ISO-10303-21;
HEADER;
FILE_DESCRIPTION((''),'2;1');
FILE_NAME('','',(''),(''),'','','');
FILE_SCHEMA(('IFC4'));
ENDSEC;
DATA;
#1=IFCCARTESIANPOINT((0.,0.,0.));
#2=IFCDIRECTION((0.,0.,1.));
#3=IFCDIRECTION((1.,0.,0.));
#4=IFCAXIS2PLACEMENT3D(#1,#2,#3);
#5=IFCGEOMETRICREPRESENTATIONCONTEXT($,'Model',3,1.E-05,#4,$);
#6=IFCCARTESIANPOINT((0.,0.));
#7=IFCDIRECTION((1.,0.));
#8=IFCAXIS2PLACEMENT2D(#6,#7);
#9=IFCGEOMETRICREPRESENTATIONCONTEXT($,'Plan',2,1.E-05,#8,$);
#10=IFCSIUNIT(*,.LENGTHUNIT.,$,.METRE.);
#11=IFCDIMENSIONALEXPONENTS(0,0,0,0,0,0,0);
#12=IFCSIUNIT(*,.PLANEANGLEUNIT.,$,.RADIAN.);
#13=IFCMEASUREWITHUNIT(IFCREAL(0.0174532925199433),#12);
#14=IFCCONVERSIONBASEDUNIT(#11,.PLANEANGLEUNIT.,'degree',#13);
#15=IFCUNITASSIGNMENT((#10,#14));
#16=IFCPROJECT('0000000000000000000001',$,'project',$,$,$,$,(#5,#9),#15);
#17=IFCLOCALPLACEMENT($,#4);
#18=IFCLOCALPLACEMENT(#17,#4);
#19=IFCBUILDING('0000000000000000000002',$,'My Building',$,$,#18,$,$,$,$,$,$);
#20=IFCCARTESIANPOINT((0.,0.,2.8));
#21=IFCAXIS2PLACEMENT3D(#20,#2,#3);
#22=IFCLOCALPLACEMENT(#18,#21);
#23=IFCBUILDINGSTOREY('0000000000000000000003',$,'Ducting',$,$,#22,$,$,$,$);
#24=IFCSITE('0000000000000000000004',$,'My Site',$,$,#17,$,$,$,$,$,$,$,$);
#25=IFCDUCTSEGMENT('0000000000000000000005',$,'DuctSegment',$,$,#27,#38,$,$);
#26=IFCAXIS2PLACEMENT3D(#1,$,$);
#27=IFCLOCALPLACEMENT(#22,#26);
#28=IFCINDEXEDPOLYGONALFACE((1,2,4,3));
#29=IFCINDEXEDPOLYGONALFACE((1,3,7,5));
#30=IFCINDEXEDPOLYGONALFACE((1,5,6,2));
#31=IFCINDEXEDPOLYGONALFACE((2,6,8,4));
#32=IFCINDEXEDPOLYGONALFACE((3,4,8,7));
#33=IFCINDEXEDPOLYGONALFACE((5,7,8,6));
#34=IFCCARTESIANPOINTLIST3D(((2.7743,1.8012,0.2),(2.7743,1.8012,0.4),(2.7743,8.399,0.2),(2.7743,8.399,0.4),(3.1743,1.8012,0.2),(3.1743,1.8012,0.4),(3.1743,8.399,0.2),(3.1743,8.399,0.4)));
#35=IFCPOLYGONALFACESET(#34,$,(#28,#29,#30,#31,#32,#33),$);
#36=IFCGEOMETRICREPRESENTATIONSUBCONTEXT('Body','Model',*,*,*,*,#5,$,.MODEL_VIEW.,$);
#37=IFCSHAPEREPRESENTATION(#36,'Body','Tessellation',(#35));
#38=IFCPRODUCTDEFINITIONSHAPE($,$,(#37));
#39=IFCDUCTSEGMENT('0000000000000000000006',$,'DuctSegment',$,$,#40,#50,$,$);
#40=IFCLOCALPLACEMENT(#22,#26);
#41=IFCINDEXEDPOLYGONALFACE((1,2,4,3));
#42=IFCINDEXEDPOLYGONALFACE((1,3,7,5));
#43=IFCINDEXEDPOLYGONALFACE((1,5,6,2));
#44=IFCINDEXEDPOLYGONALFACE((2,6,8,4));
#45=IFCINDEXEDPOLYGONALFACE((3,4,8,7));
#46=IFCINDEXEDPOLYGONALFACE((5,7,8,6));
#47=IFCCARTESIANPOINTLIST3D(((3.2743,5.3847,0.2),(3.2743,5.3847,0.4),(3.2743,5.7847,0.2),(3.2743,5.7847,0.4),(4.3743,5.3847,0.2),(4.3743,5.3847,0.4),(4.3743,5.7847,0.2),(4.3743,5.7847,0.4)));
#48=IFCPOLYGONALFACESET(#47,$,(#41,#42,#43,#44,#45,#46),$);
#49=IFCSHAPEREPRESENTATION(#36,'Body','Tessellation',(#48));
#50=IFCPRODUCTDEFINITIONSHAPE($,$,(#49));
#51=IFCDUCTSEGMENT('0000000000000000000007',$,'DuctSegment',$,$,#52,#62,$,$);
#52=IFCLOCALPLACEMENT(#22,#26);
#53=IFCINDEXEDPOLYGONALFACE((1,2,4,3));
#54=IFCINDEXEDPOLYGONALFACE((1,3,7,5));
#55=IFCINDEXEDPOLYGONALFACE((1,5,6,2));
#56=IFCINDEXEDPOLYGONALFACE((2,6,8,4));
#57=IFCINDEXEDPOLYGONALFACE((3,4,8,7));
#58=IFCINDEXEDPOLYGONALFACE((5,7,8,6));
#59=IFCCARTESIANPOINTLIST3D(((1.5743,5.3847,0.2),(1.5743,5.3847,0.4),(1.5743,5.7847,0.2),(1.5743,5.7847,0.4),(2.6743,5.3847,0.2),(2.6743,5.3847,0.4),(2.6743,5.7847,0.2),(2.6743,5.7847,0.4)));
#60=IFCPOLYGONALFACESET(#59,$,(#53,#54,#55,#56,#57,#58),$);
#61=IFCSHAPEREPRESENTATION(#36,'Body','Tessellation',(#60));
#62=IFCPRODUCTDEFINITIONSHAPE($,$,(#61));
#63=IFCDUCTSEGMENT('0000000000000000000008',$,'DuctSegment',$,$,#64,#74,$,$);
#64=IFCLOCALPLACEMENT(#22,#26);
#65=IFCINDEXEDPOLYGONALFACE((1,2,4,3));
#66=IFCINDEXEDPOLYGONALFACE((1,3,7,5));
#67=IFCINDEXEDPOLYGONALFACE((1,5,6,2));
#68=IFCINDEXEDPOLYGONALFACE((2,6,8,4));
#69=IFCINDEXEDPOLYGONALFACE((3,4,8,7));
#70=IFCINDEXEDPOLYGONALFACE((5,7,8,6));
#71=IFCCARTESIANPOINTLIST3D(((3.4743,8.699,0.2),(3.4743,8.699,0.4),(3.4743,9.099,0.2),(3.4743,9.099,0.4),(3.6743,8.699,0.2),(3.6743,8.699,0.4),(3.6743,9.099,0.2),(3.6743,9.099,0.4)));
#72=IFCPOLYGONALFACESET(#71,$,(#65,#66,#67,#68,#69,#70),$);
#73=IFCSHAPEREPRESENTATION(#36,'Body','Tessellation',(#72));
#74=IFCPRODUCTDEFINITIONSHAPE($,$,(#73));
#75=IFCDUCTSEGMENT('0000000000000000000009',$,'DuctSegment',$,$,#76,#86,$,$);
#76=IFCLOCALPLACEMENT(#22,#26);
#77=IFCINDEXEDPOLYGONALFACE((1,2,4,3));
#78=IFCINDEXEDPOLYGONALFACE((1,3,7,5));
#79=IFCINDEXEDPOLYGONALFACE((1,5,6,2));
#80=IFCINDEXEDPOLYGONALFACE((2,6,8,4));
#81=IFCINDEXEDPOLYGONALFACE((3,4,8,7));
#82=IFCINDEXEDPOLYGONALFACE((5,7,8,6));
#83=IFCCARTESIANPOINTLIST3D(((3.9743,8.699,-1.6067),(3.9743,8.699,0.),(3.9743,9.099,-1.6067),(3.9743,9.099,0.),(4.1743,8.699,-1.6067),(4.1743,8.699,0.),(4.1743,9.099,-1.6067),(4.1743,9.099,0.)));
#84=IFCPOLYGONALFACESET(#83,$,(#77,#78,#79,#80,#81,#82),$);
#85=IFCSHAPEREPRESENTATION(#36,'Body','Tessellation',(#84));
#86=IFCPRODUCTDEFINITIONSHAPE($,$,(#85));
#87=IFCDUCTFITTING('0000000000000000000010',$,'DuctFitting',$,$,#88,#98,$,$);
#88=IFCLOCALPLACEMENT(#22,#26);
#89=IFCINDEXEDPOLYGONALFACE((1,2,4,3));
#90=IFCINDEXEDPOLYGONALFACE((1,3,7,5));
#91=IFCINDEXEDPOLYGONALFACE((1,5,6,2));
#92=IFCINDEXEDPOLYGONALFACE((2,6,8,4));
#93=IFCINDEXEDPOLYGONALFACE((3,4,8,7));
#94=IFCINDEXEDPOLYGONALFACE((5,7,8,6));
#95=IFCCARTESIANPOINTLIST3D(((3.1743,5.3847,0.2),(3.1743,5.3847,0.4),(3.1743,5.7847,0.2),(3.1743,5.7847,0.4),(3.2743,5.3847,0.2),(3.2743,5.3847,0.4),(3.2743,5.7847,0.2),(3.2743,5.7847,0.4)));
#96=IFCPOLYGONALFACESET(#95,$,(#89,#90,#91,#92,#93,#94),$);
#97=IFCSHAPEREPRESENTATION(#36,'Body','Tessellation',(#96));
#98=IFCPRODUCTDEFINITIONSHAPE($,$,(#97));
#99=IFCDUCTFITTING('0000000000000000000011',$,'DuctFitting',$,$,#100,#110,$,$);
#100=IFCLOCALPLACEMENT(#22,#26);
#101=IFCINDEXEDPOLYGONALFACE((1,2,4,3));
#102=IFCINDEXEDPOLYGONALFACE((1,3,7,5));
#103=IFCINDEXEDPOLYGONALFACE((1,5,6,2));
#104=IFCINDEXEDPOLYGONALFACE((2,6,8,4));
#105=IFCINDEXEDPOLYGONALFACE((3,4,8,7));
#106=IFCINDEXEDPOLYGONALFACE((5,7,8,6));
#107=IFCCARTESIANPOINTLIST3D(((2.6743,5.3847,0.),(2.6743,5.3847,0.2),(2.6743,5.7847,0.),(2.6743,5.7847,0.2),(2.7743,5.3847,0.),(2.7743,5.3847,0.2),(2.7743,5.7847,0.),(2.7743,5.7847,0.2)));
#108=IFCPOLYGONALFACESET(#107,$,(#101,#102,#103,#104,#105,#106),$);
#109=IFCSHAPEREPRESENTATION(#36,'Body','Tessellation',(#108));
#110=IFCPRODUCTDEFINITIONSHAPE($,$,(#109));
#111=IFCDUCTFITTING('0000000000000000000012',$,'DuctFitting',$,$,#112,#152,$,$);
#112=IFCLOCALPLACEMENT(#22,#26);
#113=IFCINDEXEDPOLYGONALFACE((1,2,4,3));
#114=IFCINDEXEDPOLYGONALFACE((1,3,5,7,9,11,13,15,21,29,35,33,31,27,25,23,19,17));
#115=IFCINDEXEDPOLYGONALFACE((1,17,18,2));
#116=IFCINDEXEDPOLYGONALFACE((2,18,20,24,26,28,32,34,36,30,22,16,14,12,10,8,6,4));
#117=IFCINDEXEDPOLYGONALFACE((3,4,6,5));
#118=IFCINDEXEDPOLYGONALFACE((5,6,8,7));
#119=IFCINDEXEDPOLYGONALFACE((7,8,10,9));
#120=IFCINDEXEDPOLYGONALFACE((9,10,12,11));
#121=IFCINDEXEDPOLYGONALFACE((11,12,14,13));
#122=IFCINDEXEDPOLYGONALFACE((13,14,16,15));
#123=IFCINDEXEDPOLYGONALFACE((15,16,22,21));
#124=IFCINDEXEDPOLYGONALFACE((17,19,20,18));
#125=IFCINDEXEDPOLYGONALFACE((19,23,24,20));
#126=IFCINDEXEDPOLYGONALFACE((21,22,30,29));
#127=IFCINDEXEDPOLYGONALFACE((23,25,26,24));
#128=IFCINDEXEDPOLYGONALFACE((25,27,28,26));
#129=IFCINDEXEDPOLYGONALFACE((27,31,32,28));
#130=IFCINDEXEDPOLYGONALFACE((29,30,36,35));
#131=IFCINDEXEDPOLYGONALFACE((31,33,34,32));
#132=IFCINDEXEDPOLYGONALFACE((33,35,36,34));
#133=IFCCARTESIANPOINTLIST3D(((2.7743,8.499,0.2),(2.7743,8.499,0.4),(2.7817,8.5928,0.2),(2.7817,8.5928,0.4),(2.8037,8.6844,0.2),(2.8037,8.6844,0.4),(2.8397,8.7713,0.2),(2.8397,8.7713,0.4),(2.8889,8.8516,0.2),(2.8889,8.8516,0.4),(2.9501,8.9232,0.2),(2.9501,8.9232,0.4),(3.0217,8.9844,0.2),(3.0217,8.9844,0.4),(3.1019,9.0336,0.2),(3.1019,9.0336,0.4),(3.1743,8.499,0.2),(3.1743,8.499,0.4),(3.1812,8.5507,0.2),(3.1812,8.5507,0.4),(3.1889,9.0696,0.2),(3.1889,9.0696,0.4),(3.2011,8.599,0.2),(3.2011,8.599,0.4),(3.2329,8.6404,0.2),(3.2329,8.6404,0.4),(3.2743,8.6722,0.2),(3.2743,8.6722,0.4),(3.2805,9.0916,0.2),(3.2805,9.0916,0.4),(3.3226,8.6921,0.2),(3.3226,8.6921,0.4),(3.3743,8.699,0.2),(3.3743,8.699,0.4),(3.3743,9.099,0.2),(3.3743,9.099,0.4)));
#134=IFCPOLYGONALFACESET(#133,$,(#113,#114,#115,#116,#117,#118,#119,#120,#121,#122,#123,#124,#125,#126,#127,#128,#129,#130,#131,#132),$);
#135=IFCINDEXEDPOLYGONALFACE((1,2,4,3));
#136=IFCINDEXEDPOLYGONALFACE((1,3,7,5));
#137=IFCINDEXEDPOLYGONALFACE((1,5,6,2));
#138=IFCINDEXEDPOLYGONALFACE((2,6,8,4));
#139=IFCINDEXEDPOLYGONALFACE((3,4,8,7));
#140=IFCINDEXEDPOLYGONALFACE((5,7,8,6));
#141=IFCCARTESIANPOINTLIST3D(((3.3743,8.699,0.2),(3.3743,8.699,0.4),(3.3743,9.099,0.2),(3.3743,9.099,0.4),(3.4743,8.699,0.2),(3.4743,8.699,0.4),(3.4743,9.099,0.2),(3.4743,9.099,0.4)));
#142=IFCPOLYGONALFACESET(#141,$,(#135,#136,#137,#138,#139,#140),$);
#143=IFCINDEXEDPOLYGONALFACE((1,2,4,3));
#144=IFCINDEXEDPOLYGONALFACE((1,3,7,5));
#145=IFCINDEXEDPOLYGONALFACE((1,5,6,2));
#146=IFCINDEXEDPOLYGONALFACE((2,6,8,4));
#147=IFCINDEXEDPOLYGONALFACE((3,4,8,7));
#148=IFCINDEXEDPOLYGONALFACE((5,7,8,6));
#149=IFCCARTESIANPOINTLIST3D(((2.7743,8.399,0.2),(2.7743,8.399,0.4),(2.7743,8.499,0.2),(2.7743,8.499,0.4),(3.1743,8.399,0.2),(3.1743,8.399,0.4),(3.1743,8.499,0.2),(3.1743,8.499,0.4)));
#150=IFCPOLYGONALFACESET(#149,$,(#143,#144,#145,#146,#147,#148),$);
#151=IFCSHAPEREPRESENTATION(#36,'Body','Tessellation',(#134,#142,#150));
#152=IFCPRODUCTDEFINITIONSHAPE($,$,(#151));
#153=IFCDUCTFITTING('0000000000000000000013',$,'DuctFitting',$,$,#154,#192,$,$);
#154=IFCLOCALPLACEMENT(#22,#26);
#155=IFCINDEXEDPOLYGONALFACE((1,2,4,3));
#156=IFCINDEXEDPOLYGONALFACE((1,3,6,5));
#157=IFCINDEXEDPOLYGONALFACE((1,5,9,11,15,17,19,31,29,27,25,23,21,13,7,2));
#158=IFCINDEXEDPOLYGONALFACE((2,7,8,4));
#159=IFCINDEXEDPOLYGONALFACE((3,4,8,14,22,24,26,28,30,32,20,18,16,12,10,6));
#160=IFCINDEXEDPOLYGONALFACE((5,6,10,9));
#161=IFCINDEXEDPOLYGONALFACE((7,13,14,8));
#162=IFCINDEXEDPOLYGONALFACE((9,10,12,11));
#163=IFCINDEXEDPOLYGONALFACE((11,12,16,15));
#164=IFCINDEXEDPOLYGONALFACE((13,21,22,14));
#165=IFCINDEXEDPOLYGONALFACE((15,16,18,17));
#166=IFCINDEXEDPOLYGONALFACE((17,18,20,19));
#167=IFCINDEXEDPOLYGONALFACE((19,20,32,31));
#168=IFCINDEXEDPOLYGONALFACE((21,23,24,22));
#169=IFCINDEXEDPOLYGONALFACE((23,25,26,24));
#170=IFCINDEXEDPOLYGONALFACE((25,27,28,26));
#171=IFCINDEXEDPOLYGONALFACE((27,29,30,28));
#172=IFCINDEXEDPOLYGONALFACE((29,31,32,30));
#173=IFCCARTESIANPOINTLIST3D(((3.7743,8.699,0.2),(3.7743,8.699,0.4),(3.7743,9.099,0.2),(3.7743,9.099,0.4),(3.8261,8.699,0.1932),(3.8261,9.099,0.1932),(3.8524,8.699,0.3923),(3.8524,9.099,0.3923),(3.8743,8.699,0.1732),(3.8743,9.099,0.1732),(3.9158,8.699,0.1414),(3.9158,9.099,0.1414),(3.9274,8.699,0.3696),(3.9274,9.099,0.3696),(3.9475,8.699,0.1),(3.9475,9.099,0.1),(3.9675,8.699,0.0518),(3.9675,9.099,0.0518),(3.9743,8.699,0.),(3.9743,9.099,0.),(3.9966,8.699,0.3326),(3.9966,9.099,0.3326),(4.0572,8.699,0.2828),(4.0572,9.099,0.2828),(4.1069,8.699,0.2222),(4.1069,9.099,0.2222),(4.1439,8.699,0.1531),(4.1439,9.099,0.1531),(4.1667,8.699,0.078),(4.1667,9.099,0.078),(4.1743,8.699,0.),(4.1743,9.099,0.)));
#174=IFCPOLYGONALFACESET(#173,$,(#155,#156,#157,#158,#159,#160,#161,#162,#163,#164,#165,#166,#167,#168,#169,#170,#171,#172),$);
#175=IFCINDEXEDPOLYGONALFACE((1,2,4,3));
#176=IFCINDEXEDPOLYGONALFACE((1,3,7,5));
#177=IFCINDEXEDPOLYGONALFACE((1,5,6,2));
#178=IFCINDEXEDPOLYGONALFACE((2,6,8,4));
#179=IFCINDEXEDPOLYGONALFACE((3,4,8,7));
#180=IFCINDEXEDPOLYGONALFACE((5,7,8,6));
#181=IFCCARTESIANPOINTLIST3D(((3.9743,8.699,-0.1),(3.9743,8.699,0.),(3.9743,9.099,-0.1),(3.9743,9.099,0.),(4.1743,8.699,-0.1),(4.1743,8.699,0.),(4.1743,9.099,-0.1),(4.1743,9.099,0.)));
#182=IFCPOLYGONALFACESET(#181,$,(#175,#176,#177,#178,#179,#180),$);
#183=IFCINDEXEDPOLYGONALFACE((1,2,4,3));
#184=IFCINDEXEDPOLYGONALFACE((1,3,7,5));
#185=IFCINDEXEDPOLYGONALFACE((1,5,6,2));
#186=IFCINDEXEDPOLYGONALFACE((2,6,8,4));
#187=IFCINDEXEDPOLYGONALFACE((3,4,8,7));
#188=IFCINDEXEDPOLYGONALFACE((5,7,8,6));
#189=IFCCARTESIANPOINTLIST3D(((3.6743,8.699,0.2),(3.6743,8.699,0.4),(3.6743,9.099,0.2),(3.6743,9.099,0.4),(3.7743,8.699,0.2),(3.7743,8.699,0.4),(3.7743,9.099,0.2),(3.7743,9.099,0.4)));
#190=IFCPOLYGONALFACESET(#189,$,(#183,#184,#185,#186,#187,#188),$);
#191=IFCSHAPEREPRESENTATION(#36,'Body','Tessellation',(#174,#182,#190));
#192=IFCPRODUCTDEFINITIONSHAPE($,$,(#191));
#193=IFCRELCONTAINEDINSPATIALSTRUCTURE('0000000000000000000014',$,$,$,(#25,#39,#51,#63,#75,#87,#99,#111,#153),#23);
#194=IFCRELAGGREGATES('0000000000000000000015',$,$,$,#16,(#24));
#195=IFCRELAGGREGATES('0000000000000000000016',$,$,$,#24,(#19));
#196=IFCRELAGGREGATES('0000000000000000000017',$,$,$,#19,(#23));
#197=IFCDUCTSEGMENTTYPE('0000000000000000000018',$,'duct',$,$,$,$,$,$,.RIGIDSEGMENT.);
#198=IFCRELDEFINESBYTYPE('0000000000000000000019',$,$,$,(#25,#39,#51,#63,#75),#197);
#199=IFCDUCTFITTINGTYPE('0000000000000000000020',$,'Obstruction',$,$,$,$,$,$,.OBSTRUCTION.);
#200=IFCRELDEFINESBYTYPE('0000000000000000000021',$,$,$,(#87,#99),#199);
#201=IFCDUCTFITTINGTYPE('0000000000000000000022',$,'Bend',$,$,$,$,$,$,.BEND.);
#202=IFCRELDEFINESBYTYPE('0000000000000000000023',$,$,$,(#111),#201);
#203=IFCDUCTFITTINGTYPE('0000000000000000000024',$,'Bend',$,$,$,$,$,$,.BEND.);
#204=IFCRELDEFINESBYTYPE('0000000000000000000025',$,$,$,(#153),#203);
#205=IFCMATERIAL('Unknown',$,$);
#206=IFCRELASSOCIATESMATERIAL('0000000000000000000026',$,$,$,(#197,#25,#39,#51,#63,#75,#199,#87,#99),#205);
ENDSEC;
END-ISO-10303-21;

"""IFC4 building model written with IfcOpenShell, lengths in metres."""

from ifc_helpers import new_model, entity, si_unit, converted_unit, frame, origin_with_axes, origin_2d_with_axis, place, context, subcontext, project, spatial, line, arc, indexed_curve, rectangle, outline, extrude, source, transform, mapped, material, material_profile, profile_set, profile_usage, type_object, type_shapes, element, save


model = new_model("IFC4")

# Units and contexts
model_context = context("Model", 3, precision=1e-05, world=origin_with_axes())
plan_context = context("Plan", 2, precision=1e-05, world=origin_2d_with_axis())
body_context = subcontext(model_context, "Body", "Model", "MODEL_VIEW")
ifc_project = project(units=[si_unit("LENGTHUNIT", "METRE"), converted_unit("PLANEANGLEUNIT", "degree", entity("IfcReal", 0.0174532925199433), si_unit("PLANEANGLEUNIT", "RADIAN"), dimensions=[0, 0, 0, 0, 0, 0, 0])], contexts=[model_context, plan_context])

# Site, building, storey
site_placement = place(None, origin_with_axes())
site = spatial("IfcSite", under=ifc_project, at=site_placement, Name="My Site")
building_placement = place(site_placement, origin_with_axes())
building = spatial("IfcBuilding", under=site, at=building_placement, Name="My Building")
storey_placement = place(building_placement, frame((0.0, 0.0, 2.8), z_axis=(0.0, 0.0, 1.0), x_axis=(1.0, 0.0, 0.0)))
storey = spatial("IfcBuildingStorey", under=building, at=storey_placement, Name="Ducting")

# Duct segments
ifc_material = material(Name="Unknown")
ifc_material_profile_1 = material_profile(ifc_material, rectangle(XDim=0.4, YDim=0.2))
ifc_profile_set_1 = profile_set([ifc_material_profile_1])
ifc_profile_usage_1 = profile_usage(ifc_profile_set_1, cardinal=5)
duct_segment_type = type_object("IfcDuctSegmentType", Name="duct", PredefinedType="RIGIDSEGMENT", material=ifc_profile_set_1)
duct_segment_1_placement = place(storey_placement, frame((2.9743, 8.399, 0.3), z_axis=(0.0, -1.0, 0.0), x_axis=(1.0, 0.0, 0.0)))
element("IfcDuctSegment", 1, at=duct_segment_1_placement, inside=storey, type_object=duct_segment_type, material=ifc_profile_usage_1, Name="DuctSegment", context=body_context, shape_type="SweptSolid", body=[
    extrude(rectangle(XDim=0.4, YDim=0.2), origin_with_axes(), (0.0, 0.0, 1.0), 6.5978),
])
ifc_profile_usage_2 = profile_usage(ifc_profile_set_1, cardinal=5)
duct_segment_2_placement = place(storey_placement, frame((3.2743, 5.5847, 0.3), z_axis=(1.0, 0.0, 0.0), x_axis=(0.0, 1.0, 0.0)))
element("IfcDuctSegment", 2, at=duct_segment_2_placement, inside=storey, type_object=duct_segment_type, material=ifc_profile_usage_2, Name="DuctSegment", context=body_context, shape_type="SweptSolid", body=[
    extrude(rectangle(XDim=0.4, YDim=0.2), origin_with_axes(), (0.0, 0.0, 1.0), 1.1),
])
ifc_profile_usage_3 = profile_usage(ifc_profile_set_1, cardinal=5)
duct_segment_3_placement = place(storey_placement, frame((1.5743, 5.5847, 0.3), z_axis=(1.0, 0.0, 0.0), x_axis=(0.0, 1.0, 0.0)))
element("IfcDuctSegment", 3, at=duct_segment_3_placement, inside=storey, type_object=duct_segment_type, material=ifc_profile_usage_3, Name="DuctSegment", context=body_context, shape_type="SweptSolid", body=[
    extrude(rectangle(XDim=0.4, YDim=0.2), origin_with_axes(), (0.0, 0.0, 1.0), 1.1),
])
ifc_profile_usage_4 = profile_usage(ifc_profile_set_1, cardinal=5)
duct_segment_4_placement = place(storey_placement, frame((3.4743, 8.899, 0.3), z_axis=(1.0, 0.0, 0.0), x_axis=(0.0, 1.0, 0.0)))
element("IfcDuctSegment", 4, at=duct_segment_4_placement, inside=storey, type_object=duct_segment_type, material=ifc_profile_usage_4, Name="DuctSegment", context=body_context, shape_type="SweptSolid", body=[
    extrude(rectangle(XDim=0.4, YDim=0.2), origin_with_axes(), (0.0, 0.0, 1.0), 0.2),
])
ifc_profile_usage_5 = profile_usage(ifc_profile_set_1, cardinal=5)
duct_segment_5_placement = place(storey_placement, frame((4.0743, 8.899, 0.0), z_axis=(0.0, 0.0, -1.0), x_axis=(0.0, -1.0, 0.0)))
element("IfcDuctSegment", 5, at=duct_segment_5_placement, inside=storey, type_object=duct_segment_type, material=ifc_profile_usage_5, Name="DuctSegment", context=body_context, shape_type="SweptSolid", body=[
    extrude(rectangle(XDim=0.4, YDim=0.2), origin_with_axes(), (0.0, 0.0, 1.0), 1.6067),
])

# Duct fittings
ifc_material_profile_2 = material_profile(ifc_material, rectangle(XDim=0.4, YDim=0.2))
ifc_profile_set_2 = profile_set([ifc_material_profile_2])
ifc_profile_usage_6 = profile_usage(ifc_profile_set_2, cardinal=5)
duct_fitting_type_1 = type_object("IfcDuctFittingType", Name="Obstruction", PredefinedType="OBSTRUCTION", material=ifc_profile_set_2)
duct_fitting_1_placement = place(storey_placement, frame((3.1743, 5.5847, 0.3), z_axis=(1.0, 0.0, 0.0), x_axis=(0.0, 1.0, 0.0)))
element("IfcDuctFitting", 6, at=duct_fitting_1_placement, inside=storey, type_object=duct_fitting_type_1, material=ifc_profile_usage_6, Name="DuctFitting", context=body_context, shape_type="SweptSolid", body=[
    extrude(rectangle(XDim=0.4, YDim=0.2), origin_with_axes(), (0.0, 0.0, 1.0), 0.1),
])
ifc_profile_usage_7 = profile_usage(ifc_profile_set_2, cardinal=5)
duct_fitting_2_placement = place(storey_placement, frame((2.6743, 5.5847, 0.1), z_axis=(1.0, 0.0, 0.0), x_axis=(0.0, 1.0, 0.0)))
element("IfcDuctFitting", 7, at=duct_fitting_2_placement, inside=storey, type_object=duct_fitting_type_1, material=ifc_profile_usage_7, Name="DuctFitting", context=body_context, shape_type="SweptSolid", body=[
    extrude(rectangle(XDim=0.4, YDim=0.2), origin_with_axes(), (0.0, 0.0, 1.0), 0.1),
])
duct_fitting_type_2 = type_object("IfcDuctFittingType", Name="Bend", PredefinedType="BEND")
shared_shape_1 = source(origin_with_axes(), body_context, "Body", "SweptSolid", [
    extrude(outline(indexed_curve([(-0.2, 0.0), (-0.2586, -0.1414), (-0.4, -0.2), (-0.4, -0.6), (0.0243, -0.4243), (0.2, 0.0)], segments=[arc(1, 2, 3), line(3, 4), arc(4, 5, 6), line(6, 1)])), frame((0.0, -0.1, -0.1), z_axis=(0.0, -1.0, 0.0), x_axis=(1.0, 0.0, 0.0)), (0.0, 0.0, -1.0), 0.2),
    extrude(rectangle(XDim=0.4, YDim=0.2), origin_with_axes(), (0.0, 0.0, -1.0), 0.1),
    extrude(rectangle(XDim=0.4, YDim=0.2), frame((-0.4, 0.0, -0.5), z_axis=(-1.0, 0.0, 0.0), x_axis=(0.0, 0.0, -1.0)), (0.0, 0.0, 1.0), 0.1),
])
type_shapes(duct_fitting_type_2, [shared_shape_1])
duct_fitting_3_placement = place(storey_placement, frame((3.4743, 8.899, 0.3), z_axis=(1.0, 0.0, 0.0), x_axis=(0.0, 1.0, 0.0)))
element("IfcDuctFitting", 8, at=duct_fitting_3_placement, inside=storey, type_object=duct_fitting_type_2, Name="DuctFitting", context=body_context, shape_type="MappedRepresentation", body=[
    mapped(shared_shape_1, transform((0.0, 0.0, 0.0), x_axis=(1.0, 0.0, 0.0), y_axis=(0.0, 1.0, 0.0), z_axis=(0.0, 0.0, 1.0), scale=1.0)),
])
duct_fitting_type_3 = type_object("IfcDuctFittingType", Name="Bend", PredefinedType="BEND")
shared_shape_2 = source(origin_with_axes(), body_context, "Body", "SweptSolid", [
    extrude(outline(indexed_curve([(-0.1, 0.0), (-0.1586, -0.1414), (-0.3, -0.2), (-0.3, -0.4), (-0.0172, -0.2828), (0.1, 0.0)], segments=[arc(1, 2, 3), line(3, 4), arc(4, 5, 6), line(6, 1)])), frame((-0.2, 0.0, -0.1), z_axis=(1.0, 0.0, 0.0), x_axis=(0.0, 1.0, 0.0)), (0.0, 0.0, 1.0), 0.4),
    extrude(rectangle(XDim=0.4, YDim=0.2), origin_with_axes(), (0.0, 0.0, -1.0), 0.1),
    extrude(rectangle(XDim=0.4, YDim=0.2), frame((0.0, -0.3, -0.4), z_axis=(0.0, -1.0, 0.0), x_axis=(1.0, 0.0, 0.0)), (0.0, 0.0, 1.0), 0.1),
])
type_shapes(duct_fitting_type_3, [shared_shape_2])
duct_fitting_4_placement = place(storey_placement, frame((4.0743, 8.899, -0.1), z_axis=(0.0, 0.0, -1.0), x_axis=(0.0, 1.0, 0.0)))
element("IfcDuctFitting", 9, at=duct_fitting_4_placement, inside=storey, type_object=duct_fitting_type_3, Name="DuctFitting", context=body_context, shape_type="MappedRepresentation", body=[
    mapped(shared_shape_2, transform((0.0, 0.0, 0.0), x_axis=(1.0, 0.0, 0.0), y_axis=(0.0, 1.0, 0.0), z_axis=(0.0, 0.0, 1.0), scale=1.0)),
])

save(model, "model.ifc")
